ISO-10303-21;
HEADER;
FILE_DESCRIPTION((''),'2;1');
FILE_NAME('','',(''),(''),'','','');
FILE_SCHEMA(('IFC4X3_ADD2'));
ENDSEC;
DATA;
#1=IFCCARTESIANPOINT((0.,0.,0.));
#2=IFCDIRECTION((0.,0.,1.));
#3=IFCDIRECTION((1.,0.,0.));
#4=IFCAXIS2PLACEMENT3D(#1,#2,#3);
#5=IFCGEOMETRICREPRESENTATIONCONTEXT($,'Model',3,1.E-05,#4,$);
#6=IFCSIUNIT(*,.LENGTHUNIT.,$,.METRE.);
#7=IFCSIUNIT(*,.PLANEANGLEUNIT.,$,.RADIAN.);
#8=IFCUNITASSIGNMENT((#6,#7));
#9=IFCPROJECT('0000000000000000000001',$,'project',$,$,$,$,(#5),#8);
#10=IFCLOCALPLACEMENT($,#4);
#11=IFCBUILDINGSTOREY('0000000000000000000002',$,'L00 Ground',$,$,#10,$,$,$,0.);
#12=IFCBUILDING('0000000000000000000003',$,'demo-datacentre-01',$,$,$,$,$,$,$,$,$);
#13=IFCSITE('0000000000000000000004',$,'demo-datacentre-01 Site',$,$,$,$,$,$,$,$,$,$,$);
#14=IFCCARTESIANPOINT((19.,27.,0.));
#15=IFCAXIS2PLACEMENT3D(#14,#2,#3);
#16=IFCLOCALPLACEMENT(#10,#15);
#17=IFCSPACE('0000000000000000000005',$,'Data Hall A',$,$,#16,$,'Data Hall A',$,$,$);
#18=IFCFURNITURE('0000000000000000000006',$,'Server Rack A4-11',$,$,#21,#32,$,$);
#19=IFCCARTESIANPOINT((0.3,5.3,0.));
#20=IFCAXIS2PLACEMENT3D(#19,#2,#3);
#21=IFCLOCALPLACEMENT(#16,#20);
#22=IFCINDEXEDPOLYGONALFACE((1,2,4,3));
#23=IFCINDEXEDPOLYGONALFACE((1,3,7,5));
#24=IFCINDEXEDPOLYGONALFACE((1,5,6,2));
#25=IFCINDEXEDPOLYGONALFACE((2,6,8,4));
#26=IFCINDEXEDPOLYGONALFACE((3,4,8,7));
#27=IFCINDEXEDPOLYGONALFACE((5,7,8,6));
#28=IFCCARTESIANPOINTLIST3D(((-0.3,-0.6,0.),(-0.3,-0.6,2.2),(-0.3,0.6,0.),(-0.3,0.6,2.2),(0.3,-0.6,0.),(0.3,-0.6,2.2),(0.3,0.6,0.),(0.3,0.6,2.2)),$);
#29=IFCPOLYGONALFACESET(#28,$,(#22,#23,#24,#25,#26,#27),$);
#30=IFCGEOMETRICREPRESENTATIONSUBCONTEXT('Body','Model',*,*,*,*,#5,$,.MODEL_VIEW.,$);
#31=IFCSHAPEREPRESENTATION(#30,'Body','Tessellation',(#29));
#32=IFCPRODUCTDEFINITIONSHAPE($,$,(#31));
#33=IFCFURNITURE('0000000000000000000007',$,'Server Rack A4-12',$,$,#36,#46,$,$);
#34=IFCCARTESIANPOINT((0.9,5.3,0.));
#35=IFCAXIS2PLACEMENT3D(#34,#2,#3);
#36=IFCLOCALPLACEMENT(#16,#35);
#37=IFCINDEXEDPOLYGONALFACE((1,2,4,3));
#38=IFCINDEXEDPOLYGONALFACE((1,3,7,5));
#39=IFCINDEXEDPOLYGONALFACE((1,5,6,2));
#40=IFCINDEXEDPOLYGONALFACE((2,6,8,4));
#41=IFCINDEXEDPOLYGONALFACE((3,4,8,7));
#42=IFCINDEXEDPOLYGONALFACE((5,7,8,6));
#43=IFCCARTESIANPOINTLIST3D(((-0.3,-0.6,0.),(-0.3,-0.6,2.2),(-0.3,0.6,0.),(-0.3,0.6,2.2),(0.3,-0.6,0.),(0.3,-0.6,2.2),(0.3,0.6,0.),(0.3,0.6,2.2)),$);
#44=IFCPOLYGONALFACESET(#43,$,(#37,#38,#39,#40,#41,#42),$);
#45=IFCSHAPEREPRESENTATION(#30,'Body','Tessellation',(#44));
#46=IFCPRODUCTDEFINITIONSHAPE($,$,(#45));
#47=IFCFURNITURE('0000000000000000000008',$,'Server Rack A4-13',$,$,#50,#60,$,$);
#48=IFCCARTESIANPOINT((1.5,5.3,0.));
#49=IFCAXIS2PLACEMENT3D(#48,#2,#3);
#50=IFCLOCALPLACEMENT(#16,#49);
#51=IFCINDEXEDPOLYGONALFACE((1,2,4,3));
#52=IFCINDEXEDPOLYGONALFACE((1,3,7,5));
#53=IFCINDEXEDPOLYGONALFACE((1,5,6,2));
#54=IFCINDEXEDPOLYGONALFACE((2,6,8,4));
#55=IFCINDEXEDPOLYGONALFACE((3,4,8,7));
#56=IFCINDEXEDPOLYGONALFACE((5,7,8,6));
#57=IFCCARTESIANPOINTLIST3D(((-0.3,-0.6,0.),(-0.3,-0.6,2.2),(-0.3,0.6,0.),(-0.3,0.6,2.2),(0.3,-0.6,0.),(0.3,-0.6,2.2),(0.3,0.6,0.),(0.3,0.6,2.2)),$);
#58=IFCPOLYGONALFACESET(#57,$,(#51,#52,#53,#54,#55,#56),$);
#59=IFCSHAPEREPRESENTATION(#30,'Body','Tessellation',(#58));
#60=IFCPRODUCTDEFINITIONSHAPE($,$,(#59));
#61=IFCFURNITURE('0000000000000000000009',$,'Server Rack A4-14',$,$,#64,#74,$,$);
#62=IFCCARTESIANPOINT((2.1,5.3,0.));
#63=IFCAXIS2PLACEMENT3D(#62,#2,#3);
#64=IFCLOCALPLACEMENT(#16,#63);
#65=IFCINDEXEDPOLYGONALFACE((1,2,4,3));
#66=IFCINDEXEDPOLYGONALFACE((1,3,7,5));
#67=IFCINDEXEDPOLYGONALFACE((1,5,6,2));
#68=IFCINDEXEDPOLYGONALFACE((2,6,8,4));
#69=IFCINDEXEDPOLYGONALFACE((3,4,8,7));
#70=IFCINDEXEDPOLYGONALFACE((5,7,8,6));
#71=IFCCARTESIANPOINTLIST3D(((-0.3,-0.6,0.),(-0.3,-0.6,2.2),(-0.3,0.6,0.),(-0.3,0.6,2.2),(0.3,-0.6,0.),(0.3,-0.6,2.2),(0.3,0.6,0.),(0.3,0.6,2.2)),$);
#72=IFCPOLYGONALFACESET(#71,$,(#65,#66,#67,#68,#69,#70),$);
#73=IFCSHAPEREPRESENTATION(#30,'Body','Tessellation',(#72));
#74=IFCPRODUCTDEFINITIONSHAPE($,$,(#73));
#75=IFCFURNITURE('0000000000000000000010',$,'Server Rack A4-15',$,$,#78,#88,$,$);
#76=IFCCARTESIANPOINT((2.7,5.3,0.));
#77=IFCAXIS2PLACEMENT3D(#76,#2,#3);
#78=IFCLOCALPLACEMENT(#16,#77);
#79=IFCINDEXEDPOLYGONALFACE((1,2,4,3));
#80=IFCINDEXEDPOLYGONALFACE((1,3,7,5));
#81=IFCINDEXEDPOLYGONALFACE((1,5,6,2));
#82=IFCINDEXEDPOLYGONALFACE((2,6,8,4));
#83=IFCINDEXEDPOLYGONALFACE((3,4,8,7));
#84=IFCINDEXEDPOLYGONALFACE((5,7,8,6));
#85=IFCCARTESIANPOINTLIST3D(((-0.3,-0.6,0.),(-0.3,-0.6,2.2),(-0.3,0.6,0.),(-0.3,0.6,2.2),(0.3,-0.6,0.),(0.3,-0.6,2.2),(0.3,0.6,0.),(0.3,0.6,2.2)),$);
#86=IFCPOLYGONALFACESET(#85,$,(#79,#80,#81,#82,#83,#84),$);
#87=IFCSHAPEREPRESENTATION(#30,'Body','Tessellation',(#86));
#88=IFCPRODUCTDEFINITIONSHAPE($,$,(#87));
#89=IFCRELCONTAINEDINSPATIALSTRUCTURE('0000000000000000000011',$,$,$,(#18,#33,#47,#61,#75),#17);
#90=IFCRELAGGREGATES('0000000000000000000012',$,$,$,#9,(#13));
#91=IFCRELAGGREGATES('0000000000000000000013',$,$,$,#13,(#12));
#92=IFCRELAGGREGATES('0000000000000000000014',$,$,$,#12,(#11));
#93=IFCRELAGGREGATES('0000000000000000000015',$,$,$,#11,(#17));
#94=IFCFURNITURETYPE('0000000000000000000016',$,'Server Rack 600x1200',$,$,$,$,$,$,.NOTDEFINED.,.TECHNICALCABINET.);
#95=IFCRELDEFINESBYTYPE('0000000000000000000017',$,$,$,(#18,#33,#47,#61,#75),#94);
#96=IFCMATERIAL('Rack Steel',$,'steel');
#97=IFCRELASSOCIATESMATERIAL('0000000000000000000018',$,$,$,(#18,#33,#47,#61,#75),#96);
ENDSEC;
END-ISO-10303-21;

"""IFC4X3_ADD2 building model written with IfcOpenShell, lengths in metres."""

from ifc_helpers import new_model, si_unit, frame, origin_with_axes, place, context, subcontext, project, spatial, rectangle, extrude, material, type_object, element, save


model = new_model("IFC4X3_ADD2")

# Units and contexts
model_context = context("Model", 3, precision=1e-05, world=origin_with_axes())
body_context = subcontext(model_context, "Body", "Model", "MODEL_VIEW")
ifc_project = project(units=[si_unit("LENGTHUNIT", "METRE"), si_unit("PLANEANGLEUNIT", "RADIAN")], contexts=[model_context])

# Site, building, storey
site = spatial("IfcSite", under=ifc_project, Name="demo-datacentre-01 Site")
building = spatial("IfcBuilding", under=site, Name="demo-datacentre-01")
storey_placement = place(None, origin_with_axes())
storey = spatial("IfcBuildingStorey", under=building, at=storey_placement, Name="L00 Ground", Elevation=0.0)

# Shared definitions
space_placement = place(storey_placement, frame((19.0, 27.0, 0.0), z_axis=(0.0, 0.0, 1.0), x_axis=(1.0, 0.0, 0.0)))
space = spatial("IfcSpace", under=storey, at=space_placement, Name="Data Hall A", LongName="Data Hall A")

# Furniture
ifc_material_1 = material(Name="Rack Steel", Category="steel")
furniture_type = type_object("IfcFurnitureType", Name="Server Rack 600x1200", AssemblyPlace="NOTDEFINED", PredefinedType="TECHNICALCABINET")
for number, where, z_axis, x_axis, name in (
    (1, (0.3, 5.3, 0.0), (0.0, 0.0, 1.0), (1.0, 0.0, 0.0), "Server Rack A4-11"),
    (2, (0.9, 5.3, 0.0), (0.0, 0.0, 1.0), (1.0, 0.0, 0.0), "Server Rack A4-12"),
    (3, (1.5, 5.3, 0.0), (0.0, 0.0, 1.0), (1.0, 0.0, 0.0), "Server Rack A4-13"),
    (4, (2.1, 5.3, 0.0), (0.0, 0.0, 1.0), (1.0, 0.0, 0.0), "Server Rack A4-14"),
    (5, (2.7, 5.3, 0.0), (0.0, 0.0, 1.0), (1.0, 0.0, 0.0), "Server Rack A4-15"),
):
    element("IfcFurniture", number, at=place(space_placement, frame(where, z_axis=z_axis, x_axis=x_axis)), inside=space, type_object=furniture_type, material=ifc_material_1, Name=name, context=body_context, shape_type="SweptSolid", body=[
        extrude(rectangle(XDim=0.6, YDim=1.2), origin_with_axes(), (0.0, 0.0, 1.0), 2.2),
    ])

save(model, "model.ifc")
